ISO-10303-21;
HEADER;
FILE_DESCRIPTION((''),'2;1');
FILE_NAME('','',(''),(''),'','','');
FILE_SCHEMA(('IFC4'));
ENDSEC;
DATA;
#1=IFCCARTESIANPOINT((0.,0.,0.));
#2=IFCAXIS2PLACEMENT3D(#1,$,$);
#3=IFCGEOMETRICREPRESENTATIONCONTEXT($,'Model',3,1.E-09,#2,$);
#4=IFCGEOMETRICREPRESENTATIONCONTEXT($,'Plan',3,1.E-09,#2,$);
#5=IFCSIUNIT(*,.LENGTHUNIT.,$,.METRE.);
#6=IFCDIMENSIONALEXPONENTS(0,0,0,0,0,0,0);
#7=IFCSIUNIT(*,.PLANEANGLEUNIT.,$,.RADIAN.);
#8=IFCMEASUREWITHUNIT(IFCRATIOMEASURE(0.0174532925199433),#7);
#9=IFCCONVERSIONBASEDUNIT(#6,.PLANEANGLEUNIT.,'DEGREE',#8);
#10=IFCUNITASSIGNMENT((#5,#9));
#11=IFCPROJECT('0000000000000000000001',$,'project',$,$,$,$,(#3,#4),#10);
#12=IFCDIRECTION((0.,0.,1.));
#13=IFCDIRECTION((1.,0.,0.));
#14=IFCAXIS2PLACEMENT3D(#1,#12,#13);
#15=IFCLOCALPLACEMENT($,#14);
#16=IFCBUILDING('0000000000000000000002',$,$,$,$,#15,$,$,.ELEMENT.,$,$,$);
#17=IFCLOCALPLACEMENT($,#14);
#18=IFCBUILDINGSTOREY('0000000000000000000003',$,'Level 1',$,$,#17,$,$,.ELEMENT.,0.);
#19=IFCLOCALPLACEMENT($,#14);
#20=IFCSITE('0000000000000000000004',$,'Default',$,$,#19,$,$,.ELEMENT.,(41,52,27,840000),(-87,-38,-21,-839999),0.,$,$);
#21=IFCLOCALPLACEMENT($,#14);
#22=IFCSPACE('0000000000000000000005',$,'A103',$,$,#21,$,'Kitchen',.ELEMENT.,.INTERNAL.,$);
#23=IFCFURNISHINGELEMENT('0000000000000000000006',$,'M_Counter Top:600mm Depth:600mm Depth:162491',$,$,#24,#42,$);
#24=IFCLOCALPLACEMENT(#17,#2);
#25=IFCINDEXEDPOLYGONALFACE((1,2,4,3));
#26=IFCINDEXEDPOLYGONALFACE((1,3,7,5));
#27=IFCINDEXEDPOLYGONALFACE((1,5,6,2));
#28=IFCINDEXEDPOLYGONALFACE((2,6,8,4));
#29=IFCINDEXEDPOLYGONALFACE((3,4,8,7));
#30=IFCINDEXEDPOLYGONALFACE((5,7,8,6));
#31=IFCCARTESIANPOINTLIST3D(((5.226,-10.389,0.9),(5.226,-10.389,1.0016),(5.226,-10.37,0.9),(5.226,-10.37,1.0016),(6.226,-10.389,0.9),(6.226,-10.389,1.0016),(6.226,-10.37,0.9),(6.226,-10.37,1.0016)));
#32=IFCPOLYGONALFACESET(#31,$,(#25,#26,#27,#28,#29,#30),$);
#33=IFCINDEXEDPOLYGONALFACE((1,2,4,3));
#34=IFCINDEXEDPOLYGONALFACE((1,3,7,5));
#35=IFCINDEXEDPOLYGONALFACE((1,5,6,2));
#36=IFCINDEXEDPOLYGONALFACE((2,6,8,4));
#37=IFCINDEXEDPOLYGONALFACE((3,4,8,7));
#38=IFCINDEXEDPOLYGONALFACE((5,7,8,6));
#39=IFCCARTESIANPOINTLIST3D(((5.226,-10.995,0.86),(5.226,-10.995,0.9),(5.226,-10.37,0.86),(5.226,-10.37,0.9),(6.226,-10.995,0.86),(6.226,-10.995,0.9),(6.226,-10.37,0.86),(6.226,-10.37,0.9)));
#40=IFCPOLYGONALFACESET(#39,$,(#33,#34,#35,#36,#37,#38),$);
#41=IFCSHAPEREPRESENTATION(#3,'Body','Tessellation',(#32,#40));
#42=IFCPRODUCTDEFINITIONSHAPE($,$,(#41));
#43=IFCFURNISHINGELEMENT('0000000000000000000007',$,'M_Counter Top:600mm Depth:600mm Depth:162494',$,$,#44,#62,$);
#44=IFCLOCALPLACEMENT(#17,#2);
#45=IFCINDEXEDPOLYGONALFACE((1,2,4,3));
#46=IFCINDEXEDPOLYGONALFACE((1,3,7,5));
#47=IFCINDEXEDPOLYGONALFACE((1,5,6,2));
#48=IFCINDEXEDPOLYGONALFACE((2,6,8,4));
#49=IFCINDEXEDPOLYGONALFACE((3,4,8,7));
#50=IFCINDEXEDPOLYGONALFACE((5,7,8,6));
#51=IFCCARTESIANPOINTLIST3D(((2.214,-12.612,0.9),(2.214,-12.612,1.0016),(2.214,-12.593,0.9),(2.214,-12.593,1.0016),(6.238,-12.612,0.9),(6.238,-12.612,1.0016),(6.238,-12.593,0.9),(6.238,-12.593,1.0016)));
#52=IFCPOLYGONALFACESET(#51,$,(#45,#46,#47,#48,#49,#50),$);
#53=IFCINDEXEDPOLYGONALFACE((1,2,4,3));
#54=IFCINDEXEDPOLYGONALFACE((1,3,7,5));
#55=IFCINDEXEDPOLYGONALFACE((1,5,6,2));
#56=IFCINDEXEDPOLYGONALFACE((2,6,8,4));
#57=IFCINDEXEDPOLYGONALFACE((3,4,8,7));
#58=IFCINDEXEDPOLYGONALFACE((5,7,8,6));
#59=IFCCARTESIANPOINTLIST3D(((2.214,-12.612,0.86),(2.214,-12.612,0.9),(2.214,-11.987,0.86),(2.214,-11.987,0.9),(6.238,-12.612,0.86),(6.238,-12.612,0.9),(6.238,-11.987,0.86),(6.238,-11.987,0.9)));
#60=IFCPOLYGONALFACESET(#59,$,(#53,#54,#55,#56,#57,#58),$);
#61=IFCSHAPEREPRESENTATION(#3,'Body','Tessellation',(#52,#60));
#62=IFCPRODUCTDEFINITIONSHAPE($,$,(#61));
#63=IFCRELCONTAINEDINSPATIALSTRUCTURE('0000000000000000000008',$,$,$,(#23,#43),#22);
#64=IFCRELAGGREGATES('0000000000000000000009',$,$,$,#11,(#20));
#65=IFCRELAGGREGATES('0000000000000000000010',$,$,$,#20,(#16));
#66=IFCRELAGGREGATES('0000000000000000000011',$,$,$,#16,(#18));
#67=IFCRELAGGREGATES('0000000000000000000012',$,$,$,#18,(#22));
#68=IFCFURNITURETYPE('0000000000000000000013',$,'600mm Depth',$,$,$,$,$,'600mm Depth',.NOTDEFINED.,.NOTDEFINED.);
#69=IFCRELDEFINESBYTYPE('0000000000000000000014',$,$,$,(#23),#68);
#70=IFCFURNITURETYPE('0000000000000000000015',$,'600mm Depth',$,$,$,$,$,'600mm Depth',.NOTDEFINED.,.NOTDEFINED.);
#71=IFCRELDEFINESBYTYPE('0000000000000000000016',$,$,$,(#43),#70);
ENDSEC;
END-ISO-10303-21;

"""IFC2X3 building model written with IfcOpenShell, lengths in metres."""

from ifc_helpers import new_model, entity, si_unit, converted_unit, frame, origin, origin_with_axes, origin_2d_with_axis, place, context, project, spatial, rectangle, extrude, source, transform, mapped, type_object, type_shapes, element, save


model = new_model("IFC2X3")

# Units and contexts
model_context = context("Model", 3, precision=1e-09, world=origin())
plan_context = context("Plan", 3, precision=1e-09, world=origin())
ifc_project = project(units=[si_unit("LENGTHUNIT", "METRE"), converted_unit("PLANEANGLEUNIT", "DEGREE", entity("IfcRatioMeasure", 0.0174532925199433), si_unit("PLANEANGLEUNIT", "RADIAN"), dimensions=[0, 0, 0, 0, 0, 0, 0])], contexts=[model_context, plan_context])

# Site, building, storey, space
site_placement = place(None, origin_with_axes())
site = spatial("IfcSite", under=ifc_project, at=site_placement, Name="Default", CompositionType="ELEMENT", RefLatitude=(41, 52, 27, 840000), RefLongitude=(-87, -38, -21, -839999), RefElevation=0.0)
building_placement = place(None, origin_with_axes())
building = spatial("IfcBuilding", under=site, at=building_placement, CompositionType="ELEMENT")
storey_placement = place(None, origin_with_axes())
storey = spatial("IfcBuildingStorey", under=building, at=storey_placement, Name="Level 1", CompositionType="ELEMENT", Elevation=0.0)
space_placement = place(None, origin_with_axes())
space = spatial("IfcSpace", under=storey, at=space_placement, Name="A103", LongName="Kitchen", CompositionType="ELEMENT", InteriorOrExteriorSpace="INTERNAL")

# Furnishing elements
furniture_type_1 = type_object("IfcFurnitureType", Name="600mm Depth", ElementType="600mm Depth", AssemblyPlace="NOTDEFINED")
shared_shape_1 = source(origin(), model_context, "Body", "SweptSolid", [
    extrude(rectangle(XDim=0.0191, YDim=1.0, at=origin_2d_with_axis()), frame((-0.7005, -0.0095, 0.9), z_axis=(0.0, 0.0, 1.0), x_axis=(0.0, -1.0, 0.0)), (0.0, 0.0, 1.0), 0.1016),
    extrude(rectangle(XDim=1.0, YDim=0.625, at=origin_2d_with_axis()), frame((-0.7005, -0.3125, 0.86), z_axis=(0.0, 0.0, 1.0), x_axis=(-1.0, 0.0, 0.0)), (0.0, 0.0, 1.0), 0.04),
])
type_shapes(furniture_type_1, [shared_shape_1])
furnishing_1_placement = place(None, frame((6.4265, -10.37, 0.0), z_axis=(0.0, 0.0, 1.0), x_axis=(1.0, 0.0, 0.0)))
element("IfcFurnishingElement", 1, at=furnishing_1_placement, inside=space, type_object=furniture_type_1, Name="M_Counter Top:600mm Depth:600mm Depth:162491", context=model_context, shape_type="MappedRepresentation", body=[
    mapped(shared_shape_1, transform((0.0, 0.0, 0.0), scale=1.0)),
])
furniture_type_2 = type_object("IfcFurnitureType", Name="600mm Depth", ElementType="600mm Depth", AssemblyPlace="NOTDEFINED")
shared_shape_2 = source(origin(), model_context, "Body", "SweptSolid", [
    extrude(rectangle(XDim=0.0191, YDim=4.024, at=origin_2d_with_axis()), frame((0.8115, -0.0095, 0.9), z_axis=(0.0, 0.0, 1.0), x_axis=(0.0, -1.0, 0.0)), (0.0, 0.0, 1.0), 0.1016),
    extrude(rectangle(XDim=4.024, YDim=0.625, at=origin_2d_with_axis()), frame((0.8115, -0.3125, 0.86), z_axis=(0.0, 0.0, 1.0), x_axis=(-1.0, 0.0, 0.0)), (0.0, 0.0, 1.0), 0.04),
])
type_shapes(furniture_type_2, [shared_shape_2])
furnishing_2_placement = place(None, frame((5.0375, -12.612, 0.0), z_axis=(0.0, 0.0, 1.0), x_axis=(-1.0, 0.0, 0.0)))
element("IfcFurnishingElement", 2, at=furnishing_2_placement, inside=space, type_object=furniture_type_2, Name="M_Counter Top:600mm Depth:600mm Depth:162494", context=model_context, shape_type="MappedRepresentation", body=[
    mapped(shared_shape_2, transform((0.0, 0.0, 0.0), scale=1.0)),
])

save(model, "model.ifc")
